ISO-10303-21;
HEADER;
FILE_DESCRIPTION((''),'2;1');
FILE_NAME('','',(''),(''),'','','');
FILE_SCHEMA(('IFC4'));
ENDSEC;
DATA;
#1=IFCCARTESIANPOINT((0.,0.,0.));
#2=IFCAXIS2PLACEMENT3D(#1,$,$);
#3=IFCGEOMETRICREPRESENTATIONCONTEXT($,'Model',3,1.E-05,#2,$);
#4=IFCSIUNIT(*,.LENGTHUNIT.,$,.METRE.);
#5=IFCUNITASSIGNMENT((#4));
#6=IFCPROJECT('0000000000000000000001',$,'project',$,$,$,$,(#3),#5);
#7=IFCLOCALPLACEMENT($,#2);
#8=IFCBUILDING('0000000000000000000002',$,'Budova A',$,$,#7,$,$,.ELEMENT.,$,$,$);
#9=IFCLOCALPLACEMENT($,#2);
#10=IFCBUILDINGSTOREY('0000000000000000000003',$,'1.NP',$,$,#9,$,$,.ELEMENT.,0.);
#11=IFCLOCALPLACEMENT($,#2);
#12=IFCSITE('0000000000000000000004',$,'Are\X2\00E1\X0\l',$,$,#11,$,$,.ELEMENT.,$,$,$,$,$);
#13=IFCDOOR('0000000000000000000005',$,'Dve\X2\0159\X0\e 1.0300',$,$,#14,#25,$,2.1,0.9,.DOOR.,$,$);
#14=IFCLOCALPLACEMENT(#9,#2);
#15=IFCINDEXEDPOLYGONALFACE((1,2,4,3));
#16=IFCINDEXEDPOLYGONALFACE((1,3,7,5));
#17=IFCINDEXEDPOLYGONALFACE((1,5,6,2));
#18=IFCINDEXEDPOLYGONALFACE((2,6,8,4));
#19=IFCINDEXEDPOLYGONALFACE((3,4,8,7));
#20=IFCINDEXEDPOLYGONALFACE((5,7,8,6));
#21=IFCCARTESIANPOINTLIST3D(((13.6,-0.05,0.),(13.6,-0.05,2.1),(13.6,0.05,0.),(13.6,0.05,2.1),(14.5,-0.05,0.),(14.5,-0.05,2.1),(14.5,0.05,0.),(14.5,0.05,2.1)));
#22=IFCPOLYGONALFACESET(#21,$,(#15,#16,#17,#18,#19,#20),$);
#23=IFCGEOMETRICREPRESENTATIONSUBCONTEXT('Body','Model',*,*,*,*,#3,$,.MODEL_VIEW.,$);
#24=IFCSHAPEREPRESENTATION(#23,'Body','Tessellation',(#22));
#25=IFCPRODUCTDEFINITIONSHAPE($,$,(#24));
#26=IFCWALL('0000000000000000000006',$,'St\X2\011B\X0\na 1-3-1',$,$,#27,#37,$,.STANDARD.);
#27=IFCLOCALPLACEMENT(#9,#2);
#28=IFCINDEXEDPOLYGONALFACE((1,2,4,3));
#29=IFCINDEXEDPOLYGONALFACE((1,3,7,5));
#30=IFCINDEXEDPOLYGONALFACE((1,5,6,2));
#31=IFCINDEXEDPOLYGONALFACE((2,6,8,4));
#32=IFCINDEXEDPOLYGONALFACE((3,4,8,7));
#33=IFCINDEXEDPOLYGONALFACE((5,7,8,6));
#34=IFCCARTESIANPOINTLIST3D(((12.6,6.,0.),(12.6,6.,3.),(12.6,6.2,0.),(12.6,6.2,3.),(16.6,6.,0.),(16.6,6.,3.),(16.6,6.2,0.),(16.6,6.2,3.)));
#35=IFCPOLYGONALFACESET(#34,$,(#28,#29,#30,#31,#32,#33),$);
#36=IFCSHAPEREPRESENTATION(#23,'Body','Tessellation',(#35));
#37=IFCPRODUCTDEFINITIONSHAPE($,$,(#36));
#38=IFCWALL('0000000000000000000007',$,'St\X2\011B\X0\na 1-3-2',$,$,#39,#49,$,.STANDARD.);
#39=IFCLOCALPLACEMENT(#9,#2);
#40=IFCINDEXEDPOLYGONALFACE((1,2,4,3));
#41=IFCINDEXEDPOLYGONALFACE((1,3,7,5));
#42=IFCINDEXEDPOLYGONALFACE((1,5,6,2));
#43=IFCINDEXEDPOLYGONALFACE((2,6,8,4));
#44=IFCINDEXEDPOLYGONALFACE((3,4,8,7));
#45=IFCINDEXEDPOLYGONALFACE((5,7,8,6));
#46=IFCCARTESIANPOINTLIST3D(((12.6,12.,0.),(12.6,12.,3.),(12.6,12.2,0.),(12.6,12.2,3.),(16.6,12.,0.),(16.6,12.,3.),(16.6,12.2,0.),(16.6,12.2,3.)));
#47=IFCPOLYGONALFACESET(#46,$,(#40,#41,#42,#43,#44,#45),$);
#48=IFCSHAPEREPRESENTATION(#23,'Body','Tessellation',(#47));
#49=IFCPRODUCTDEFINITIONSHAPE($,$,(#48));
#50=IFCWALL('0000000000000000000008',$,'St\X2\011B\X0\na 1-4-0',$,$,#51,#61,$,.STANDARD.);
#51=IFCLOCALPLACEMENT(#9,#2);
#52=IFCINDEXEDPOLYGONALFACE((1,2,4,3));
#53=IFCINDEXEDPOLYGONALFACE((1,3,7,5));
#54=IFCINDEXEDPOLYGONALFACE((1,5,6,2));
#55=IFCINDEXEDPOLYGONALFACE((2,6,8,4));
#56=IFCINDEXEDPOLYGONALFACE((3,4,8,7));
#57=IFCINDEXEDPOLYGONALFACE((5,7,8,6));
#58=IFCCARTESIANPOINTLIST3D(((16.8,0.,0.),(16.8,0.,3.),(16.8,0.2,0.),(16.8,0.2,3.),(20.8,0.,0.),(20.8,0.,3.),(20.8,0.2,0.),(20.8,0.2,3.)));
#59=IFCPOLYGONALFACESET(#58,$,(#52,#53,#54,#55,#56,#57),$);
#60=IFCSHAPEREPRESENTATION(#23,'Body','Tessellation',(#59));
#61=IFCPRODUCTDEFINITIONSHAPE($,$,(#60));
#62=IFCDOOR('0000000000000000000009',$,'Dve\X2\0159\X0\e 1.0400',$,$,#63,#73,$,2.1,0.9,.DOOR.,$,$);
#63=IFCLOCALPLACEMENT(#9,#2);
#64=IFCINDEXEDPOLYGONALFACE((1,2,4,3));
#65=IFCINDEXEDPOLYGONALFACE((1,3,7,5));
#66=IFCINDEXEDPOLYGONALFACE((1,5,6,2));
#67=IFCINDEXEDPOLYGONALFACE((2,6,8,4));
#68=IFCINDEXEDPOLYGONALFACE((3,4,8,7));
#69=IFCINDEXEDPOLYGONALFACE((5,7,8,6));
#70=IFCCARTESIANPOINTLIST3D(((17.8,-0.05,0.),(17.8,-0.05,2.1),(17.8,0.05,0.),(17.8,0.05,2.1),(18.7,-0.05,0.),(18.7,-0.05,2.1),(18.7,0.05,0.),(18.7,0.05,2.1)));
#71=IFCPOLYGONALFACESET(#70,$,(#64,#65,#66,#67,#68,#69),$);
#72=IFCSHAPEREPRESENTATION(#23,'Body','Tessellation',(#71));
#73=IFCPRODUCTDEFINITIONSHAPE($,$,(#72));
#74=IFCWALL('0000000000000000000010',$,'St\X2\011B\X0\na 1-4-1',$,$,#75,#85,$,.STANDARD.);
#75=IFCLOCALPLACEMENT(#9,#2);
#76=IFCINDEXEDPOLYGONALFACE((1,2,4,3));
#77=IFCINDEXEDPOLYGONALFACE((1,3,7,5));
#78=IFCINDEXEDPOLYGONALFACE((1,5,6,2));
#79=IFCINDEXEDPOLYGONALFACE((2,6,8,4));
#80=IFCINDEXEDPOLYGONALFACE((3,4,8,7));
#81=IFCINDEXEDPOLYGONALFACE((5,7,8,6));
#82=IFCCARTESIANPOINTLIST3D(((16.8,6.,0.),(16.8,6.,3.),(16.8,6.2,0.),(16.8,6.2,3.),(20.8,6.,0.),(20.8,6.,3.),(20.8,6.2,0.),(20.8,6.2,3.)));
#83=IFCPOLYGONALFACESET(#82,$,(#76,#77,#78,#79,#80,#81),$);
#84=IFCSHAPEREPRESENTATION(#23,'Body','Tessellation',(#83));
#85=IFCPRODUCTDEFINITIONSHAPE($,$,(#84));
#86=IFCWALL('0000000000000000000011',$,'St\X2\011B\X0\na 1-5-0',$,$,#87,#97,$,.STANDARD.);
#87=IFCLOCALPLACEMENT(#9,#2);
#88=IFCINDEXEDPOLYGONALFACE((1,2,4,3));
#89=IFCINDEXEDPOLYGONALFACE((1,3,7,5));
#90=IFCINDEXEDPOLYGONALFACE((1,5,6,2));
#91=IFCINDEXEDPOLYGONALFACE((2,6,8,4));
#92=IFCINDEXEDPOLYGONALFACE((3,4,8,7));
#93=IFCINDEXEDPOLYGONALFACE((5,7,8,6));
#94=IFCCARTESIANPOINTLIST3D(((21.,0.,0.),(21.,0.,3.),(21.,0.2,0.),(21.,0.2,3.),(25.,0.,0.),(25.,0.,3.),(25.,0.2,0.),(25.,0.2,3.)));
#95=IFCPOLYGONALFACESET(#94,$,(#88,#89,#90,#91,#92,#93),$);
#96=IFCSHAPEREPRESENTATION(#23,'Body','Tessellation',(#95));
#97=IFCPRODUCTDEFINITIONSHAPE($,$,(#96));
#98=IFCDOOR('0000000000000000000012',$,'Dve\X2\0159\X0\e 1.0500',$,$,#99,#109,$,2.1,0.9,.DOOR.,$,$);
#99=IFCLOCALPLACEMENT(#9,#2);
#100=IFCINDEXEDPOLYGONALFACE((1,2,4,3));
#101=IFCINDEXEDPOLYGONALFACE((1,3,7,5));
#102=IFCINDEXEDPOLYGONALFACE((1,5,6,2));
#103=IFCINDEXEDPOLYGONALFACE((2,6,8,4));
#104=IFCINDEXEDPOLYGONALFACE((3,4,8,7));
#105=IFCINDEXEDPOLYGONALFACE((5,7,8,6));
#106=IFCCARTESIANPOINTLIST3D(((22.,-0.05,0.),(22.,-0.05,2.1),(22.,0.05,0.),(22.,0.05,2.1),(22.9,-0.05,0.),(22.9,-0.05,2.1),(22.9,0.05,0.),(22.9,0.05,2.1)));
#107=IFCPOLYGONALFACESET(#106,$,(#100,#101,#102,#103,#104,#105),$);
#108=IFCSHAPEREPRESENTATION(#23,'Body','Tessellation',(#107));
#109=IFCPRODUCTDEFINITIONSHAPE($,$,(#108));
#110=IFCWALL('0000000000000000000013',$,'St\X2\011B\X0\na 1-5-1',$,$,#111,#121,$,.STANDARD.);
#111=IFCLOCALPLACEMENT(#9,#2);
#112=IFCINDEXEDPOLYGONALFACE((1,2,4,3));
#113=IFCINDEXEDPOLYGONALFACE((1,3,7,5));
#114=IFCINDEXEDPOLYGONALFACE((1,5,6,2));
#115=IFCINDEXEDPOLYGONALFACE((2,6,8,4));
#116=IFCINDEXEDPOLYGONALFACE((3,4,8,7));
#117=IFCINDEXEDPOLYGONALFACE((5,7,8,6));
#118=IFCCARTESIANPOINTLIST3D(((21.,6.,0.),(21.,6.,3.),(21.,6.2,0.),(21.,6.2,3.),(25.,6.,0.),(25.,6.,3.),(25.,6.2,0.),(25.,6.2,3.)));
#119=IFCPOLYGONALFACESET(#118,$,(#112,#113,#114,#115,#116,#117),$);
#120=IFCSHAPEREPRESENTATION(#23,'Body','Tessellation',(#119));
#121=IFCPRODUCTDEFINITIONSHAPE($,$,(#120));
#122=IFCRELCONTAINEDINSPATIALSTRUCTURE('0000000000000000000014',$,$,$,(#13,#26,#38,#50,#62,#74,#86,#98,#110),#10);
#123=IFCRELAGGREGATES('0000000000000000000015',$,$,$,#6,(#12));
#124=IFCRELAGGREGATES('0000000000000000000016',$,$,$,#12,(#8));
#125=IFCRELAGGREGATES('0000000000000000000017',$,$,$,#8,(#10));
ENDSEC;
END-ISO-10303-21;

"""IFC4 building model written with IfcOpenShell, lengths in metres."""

from ifc_helpers import new_model, si_unit, frame, frame_2d, origin, place, context, subcontext, project, spatial, rectangle, extrude, element, save


model = new_model("IFC4")

# Units and contexts
model_context = context("Model", 3, precision=1e-05, world=origin())
body_context = subcontext(model_context, "Body", "Model", "MODEL_VIEW")
ifc_project = project(units=[si_unit("LENGTHUNIT", "METRE")], contexts=[model_context])

# Site, building, storey
site_placement = place(None, origin())
site = spatial("IfcSite", under=ifc_project, at=site_placement, Name="Areál", CompositionType="ELEMENT")
building_placement = place(None, origin())
building = spatial("IfcBuilding", under=site, at=building_placement, Name="Budova A", CompositionType="ELEMENT")
storey_placement = place(None, origin())
storey = spatial("IfcBuildingStorey", under=building, at=storey_placement, Name="1.NP", CompositionType="ELEMENT", Elevation=0.0)

# Door
door_1_placement = place(storey_placement, frame((13.6, -0.05, 0.0)))
element("IfcDoor", 1, at=door_1_placement, inside=storey, Name="Dveře 1.0300", OverallHeight=2.1, OverallWidth=0.9, PredefinedType="DOOR", context=body_context, shape_type="SweptSolid", body=[
    extrude(rectangle(XDim=0.9, YDim=0.1, at=frame_2d((0.45, 0.05))), origin(), (0.0, 0.0, 1.0), 2.1),
])

# Walls
for number, where, name in (
    (2, (12.6, 6.0, 0.0), "Stěna 1-3-1"),
    (3, (12.6, 12.0, 0.0), "Stěna 1-3-2"),
    (4, (16.8, 0.0, 0.0), "Stěna 1-4-0"),
):
    element("IfcWall", number, at=place(storey_placement, frame(where)), inside=storey, Name=name, PredefinedType="STANDARD", context=body_context, shape_type="SweptSolid", body=[
        extrude(rectangle(XDim=4.0, YDim=0.2, at=frame_2d((2.0, 0.1))), origin(), (0.0, 0.0, 1.0), 3.0),
    ])

# Door
door_2_placement = place(storey_placement, frame((17.8, -0.05, 0.0)))
element("IfcDoor", 5, at=door_2_placement, inside=storey, Name="Dveře 1.0400", OverallHeight=2.1, OverallWidth=0.9, PredefinedType="DOOR", context=body_context, shape_type="SweptSolid", body=[
    extrude(rectangle(XDim=0.9, YDim=0.1, at=frame_2d((0.45, 0.05))), origin(), (0.0, 0.0, 1.0), 2.1),
])

# Walls
for number, where, name in (
    (6, (16.8, 6.0, 0.0), "Stěna 1-4-1"),
    (7, (21.0, 0.0, 0.0), "Stěna 1-5-0"),
):
    element("IfcWall", number, at=place(storey_placement, frame(where)), inside=storey, Name=name, PredefinedType="STANDARD", context=body_context, shape_type="SweptSolid", body=[
        extrude(rectangle(XDim=4.0, YDim=0.2, at=frame_2d((2.0, 0.1))), origin(), (0.0, 0.0, 1.0), 3.0),
    ])

# Door
door_3_placement = place(storey_placement, frame((22.0, -0.05, 0.0)))
element("IfcDoor", 8, at=door_3_placement, inside=storey, Name="Dveře 1.0500", OverallHeight=2.1, OverallWidth=0.9, PredefinedType="DOOR", context=body_context, shape_type="SweptSolid", body=[
    extrude(rectangle(XDim=0.9, YDim=0.1, at=frame_2d((0.45, 0.05))), origin(), (0.0, 0.0, 1.0), 2.1),
])

# Wall
wall_1_placement = place(storey_placement, frame((21.0, 6.0, 0.0)))
element("IfcWall", 9, at=wall_1_placement, inside=storey, Name="Stěna 1-5-1", PredefinedType="STANDARD", context=body_context, shape_type="SweptSolid", body=[
    extrude(rectangle(XDim=4.0, YDim=0.2, at=frame_2d((2.0, 0.1))), origin(), (0.0, 0.0, 1.0), 3.0),
])

save(model, "model.ifc")
